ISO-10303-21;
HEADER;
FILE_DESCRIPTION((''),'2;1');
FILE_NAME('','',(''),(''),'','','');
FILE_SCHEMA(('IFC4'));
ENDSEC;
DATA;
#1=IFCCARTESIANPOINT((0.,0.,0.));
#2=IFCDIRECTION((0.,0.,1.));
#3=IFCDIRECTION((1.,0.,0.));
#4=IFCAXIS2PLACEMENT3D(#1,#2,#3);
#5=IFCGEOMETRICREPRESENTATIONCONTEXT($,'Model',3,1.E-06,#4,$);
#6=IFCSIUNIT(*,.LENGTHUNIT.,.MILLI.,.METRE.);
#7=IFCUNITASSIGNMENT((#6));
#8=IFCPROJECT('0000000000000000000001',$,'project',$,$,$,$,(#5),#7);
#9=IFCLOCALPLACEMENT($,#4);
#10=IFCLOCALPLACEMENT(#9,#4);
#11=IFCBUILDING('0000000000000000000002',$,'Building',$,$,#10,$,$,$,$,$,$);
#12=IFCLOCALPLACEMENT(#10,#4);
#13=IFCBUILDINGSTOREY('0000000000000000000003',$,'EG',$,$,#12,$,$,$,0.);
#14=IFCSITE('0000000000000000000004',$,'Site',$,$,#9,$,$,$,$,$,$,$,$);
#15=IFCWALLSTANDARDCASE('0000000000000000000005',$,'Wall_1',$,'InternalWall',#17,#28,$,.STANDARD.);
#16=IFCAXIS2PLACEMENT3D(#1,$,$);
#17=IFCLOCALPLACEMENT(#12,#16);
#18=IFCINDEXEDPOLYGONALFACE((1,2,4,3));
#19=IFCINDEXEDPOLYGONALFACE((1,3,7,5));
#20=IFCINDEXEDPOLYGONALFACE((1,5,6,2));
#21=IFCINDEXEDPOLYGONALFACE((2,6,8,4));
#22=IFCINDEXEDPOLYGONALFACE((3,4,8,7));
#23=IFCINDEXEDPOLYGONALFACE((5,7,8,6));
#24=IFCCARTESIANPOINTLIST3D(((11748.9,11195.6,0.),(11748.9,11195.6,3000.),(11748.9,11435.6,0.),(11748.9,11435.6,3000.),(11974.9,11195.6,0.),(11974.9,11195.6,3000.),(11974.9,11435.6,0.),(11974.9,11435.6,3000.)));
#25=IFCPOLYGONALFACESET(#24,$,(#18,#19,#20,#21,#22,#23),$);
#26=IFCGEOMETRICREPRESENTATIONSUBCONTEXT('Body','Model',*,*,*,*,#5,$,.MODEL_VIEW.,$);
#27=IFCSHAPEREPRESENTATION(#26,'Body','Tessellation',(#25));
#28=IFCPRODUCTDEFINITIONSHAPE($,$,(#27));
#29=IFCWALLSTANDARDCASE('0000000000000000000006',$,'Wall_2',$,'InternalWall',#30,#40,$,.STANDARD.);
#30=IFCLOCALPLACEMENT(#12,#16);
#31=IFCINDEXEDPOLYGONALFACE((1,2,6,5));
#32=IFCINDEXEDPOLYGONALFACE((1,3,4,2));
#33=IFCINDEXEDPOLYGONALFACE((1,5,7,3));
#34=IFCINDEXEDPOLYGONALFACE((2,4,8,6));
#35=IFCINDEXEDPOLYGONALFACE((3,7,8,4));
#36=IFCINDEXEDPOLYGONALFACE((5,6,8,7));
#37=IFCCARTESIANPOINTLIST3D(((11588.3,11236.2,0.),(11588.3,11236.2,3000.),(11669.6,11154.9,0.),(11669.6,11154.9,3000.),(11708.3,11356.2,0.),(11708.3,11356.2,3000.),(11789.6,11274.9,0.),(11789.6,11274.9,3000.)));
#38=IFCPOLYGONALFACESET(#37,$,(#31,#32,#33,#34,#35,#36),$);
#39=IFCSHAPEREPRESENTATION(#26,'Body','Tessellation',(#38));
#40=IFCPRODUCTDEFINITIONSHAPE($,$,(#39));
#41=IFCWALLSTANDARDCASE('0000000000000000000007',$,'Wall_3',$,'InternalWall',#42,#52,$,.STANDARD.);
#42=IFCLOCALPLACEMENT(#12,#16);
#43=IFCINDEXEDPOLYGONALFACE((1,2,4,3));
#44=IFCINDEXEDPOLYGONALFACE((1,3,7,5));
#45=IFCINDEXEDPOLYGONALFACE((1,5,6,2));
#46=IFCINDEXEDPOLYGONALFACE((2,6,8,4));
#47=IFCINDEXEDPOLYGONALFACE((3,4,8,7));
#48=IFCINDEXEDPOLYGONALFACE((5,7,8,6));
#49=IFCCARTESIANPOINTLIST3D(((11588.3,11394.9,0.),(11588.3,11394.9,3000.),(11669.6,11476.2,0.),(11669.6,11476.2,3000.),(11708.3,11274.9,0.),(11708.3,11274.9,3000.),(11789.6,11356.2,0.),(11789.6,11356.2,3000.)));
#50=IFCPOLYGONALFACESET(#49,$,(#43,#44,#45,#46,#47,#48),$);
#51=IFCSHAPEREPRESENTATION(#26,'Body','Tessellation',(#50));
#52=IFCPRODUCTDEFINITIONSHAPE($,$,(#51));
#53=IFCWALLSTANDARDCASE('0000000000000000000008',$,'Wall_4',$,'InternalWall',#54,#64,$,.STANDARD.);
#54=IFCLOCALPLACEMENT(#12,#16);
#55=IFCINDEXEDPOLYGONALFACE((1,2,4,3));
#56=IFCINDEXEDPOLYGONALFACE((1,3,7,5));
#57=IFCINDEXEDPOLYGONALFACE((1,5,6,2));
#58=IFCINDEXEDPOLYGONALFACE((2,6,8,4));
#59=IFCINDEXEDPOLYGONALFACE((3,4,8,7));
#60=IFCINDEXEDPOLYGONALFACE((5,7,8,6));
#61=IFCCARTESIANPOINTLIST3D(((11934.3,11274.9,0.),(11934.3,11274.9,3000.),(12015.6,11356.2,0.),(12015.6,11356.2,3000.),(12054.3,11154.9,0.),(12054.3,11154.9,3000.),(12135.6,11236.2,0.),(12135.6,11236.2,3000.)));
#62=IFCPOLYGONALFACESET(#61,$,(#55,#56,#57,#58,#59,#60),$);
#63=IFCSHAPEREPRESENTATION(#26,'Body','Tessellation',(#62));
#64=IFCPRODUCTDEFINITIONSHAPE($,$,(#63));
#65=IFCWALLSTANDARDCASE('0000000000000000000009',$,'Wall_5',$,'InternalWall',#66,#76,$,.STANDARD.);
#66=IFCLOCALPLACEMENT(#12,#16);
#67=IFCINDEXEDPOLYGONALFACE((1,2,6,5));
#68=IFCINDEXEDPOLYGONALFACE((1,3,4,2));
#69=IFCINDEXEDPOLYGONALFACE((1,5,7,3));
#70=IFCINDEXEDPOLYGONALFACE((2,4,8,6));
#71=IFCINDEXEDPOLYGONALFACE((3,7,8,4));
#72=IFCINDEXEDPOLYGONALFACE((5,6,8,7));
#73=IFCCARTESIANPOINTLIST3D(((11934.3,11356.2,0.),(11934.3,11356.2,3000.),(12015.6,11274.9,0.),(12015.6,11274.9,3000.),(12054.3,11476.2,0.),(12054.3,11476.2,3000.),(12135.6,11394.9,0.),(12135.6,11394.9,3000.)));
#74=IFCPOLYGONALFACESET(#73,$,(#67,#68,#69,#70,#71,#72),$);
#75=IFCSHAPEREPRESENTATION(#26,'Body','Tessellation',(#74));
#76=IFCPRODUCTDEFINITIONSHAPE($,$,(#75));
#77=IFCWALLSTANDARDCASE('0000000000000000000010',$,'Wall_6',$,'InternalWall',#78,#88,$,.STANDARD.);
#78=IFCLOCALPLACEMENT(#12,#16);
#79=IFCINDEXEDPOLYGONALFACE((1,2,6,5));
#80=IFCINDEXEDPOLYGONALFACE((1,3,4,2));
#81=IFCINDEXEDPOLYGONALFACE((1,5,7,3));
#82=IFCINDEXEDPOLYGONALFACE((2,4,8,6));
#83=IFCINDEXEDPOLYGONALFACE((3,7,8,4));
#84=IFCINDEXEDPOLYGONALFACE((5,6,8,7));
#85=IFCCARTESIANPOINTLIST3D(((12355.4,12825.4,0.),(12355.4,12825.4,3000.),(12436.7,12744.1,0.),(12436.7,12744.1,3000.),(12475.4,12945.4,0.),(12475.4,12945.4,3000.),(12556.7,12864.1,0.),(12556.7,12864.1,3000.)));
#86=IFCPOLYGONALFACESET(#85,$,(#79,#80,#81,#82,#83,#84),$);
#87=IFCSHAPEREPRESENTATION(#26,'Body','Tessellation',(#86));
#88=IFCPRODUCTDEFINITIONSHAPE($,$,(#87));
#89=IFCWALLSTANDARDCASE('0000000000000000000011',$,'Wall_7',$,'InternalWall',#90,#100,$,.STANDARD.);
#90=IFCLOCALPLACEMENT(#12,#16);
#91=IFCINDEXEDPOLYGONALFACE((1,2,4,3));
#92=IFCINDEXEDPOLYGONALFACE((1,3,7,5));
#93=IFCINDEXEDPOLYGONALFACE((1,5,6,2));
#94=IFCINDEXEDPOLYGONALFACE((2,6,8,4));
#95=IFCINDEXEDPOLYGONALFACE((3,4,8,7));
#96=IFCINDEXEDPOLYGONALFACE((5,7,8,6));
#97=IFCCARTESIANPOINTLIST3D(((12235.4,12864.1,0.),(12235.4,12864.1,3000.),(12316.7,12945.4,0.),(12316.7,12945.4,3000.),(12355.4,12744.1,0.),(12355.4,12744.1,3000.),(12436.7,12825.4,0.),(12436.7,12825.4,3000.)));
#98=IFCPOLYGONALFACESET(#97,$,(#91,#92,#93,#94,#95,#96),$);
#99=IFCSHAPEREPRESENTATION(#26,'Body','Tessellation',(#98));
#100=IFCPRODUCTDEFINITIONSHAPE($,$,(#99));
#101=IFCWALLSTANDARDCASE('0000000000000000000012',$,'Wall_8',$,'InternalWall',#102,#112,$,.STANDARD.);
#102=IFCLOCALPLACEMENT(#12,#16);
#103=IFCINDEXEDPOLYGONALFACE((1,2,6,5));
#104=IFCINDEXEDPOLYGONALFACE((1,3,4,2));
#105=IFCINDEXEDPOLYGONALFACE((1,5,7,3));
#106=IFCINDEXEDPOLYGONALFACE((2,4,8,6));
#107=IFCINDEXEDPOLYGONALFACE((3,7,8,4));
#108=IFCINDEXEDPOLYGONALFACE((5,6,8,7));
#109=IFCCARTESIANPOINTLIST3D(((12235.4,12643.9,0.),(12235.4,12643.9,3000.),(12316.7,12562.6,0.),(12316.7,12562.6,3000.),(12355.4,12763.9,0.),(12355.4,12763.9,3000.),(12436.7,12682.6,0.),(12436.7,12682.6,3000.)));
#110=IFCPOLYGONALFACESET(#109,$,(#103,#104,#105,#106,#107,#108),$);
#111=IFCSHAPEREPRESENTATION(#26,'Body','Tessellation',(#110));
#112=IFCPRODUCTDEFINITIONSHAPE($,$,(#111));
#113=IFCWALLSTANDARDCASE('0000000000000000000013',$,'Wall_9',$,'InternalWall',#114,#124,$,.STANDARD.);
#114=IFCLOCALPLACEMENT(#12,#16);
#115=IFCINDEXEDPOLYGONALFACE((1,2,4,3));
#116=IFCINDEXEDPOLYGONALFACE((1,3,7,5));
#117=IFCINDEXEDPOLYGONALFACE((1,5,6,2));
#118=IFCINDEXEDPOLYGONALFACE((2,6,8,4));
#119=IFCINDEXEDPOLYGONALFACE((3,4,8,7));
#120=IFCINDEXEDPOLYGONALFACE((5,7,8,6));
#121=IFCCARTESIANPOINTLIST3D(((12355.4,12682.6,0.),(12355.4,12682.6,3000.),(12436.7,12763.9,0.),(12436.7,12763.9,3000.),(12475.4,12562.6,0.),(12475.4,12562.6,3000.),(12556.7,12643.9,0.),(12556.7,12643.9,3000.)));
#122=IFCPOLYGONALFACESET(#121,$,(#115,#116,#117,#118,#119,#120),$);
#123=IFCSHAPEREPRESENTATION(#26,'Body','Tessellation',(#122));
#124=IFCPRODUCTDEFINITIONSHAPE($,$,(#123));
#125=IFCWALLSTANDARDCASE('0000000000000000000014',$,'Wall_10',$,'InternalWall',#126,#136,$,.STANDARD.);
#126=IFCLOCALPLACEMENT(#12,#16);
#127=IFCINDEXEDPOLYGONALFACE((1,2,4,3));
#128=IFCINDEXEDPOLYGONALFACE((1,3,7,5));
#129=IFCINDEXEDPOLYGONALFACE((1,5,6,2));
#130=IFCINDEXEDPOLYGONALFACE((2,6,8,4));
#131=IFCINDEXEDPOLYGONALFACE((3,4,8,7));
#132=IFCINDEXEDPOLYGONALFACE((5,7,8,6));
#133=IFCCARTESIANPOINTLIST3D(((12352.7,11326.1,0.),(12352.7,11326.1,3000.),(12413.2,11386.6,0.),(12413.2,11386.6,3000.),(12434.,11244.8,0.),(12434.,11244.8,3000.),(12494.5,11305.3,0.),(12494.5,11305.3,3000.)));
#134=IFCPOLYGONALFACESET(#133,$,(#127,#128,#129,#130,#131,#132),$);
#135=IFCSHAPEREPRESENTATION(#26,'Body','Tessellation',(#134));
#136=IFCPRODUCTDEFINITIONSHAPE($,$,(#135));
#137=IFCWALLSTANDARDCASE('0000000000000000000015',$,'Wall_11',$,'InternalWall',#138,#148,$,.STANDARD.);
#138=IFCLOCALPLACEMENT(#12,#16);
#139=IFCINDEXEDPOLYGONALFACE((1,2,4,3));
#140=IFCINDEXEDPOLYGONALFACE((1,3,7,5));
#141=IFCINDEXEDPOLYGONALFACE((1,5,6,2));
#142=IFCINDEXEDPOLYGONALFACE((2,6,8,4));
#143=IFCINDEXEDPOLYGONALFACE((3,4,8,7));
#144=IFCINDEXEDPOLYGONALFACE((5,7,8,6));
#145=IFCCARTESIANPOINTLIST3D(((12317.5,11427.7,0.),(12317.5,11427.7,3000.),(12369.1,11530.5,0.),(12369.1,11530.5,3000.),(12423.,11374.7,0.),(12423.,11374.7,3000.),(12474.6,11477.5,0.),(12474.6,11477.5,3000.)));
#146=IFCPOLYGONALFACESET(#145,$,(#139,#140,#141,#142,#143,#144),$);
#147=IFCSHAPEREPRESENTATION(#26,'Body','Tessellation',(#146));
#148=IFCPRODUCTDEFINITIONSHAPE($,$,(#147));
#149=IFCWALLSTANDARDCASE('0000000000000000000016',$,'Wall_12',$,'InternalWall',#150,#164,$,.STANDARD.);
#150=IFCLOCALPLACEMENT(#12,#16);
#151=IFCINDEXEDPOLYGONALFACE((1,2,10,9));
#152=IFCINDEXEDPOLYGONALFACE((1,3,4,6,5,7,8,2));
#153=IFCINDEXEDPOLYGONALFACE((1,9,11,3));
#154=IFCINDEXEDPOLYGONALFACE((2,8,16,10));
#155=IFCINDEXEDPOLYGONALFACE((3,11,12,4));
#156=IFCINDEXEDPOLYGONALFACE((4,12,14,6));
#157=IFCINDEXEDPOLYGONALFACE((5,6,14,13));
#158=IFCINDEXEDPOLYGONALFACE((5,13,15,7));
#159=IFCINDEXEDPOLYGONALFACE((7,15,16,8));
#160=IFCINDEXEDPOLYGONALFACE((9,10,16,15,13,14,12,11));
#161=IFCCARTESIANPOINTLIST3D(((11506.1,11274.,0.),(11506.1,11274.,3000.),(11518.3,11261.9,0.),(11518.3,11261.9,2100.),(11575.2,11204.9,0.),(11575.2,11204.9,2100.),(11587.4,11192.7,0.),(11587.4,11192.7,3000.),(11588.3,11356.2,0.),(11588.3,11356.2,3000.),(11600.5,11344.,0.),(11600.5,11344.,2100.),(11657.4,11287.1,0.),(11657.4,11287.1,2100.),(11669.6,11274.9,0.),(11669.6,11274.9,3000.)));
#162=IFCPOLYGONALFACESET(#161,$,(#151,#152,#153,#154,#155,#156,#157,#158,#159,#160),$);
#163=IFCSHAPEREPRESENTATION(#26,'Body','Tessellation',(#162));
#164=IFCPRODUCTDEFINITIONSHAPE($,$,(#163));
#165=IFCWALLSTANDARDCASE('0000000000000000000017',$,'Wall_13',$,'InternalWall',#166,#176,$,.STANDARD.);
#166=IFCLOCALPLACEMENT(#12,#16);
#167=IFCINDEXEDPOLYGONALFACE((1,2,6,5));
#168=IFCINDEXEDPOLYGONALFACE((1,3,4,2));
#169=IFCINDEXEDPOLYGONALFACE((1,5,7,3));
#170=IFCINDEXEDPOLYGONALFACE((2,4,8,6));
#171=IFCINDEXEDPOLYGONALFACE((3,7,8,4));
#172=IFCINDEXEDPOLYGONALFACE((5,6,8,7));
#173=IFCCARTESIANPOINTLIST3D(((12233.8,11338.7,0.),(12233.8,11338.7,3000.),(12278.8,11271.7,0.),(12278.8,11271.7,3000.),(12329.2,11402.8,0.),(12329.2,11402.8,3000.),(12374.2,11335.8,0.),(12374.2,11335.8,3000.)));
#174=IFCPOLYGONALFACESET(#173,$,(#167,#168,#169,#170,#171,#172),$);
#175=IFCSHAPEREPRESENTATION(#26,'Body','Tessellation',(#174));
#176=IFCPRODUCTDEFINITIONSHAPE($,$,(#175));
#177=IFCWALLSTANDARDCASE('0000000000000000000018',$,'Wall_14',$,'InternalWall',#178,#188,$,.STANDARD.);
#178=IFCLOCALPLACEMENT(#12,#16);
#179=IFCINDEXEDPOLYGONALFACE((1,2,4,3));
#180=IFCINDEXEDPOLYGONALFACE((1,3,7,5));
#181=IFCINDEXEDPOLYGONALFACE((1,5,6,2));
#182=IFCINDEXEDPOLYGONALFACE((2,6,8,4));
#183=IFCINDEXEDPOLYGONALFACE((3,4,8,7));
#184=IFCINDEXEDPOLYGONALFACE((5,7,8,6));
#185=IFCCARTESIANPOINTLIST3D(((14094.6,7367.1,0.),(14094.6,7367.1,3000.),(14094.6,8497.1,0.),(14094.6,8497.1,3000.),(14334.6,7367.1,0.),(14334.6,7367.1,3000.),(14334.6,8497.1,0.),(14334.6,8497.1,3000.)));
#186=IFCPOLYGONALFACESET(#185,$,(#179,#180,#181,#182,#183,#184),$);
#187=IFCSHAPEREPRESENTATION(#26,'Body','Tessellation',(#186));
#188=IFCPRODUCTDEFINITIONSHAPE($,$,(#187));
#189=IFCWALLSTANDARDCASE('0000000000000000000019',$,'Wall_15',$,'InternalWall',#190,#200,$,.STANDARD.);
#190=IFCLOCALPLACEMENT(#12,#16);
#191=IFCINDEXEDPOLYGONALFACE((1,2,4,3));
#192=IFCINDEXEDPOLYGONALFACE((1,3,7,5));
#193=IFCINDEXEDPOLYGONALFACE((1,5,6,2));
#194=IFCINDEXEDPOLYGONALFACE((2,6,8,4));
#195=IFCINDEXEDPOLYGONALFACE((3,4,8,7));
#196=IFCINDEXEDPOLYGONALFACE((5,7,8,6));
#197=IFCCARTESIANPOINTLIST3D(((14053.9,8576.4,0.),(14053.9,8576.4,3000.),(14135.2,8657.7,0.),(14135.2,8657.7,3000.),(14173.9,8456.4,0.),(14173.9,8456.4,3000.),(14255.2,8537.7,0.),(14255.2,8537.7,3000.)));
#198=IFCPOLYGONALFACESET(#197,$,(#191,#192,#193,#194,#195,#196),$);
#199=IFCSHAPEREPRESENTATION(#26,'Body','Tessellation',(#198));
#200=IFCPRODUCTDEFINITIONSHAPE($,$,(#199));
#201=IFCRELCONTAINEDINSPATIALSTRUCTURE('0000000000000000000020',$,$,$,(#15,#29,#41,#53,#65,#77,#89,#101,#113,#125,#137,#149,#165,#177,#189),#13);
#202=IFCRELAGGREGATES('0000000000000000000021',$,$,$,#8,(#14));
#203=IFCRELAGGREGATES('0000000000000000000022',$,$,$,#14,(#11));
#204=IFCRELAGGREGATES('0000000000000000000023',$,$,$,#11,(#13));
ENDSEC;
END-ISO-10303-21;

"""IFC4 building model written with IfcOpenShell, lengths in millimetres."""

from ifc_helpers import new_model, si_unit, frame, origin_with_axes, place, context, subcontext, project, spatial, rectangle, extrude, element, save


model = new_model("IFC4")

# Units and contexts
model_context = context("Model", 3, precision=1e-06, world=origin_with_axes())
body_context = subcontext(model_context, "Body", "Model", "MODEL_VIEW")
ifc_project = project(units=[si_unit("LENGTHUNIT", "METRE", prefix="MILLI")], contexts=[model_context])

# Site, building, storey
site_placement = place(None, origin_with_axes())
site = spatial("IfcSite", under=ifc_project, at=site_placement, Name="Site")
building_placement = place(site_placement, origin_with_axes())
building = spatial("IfcBuilding", under=site, at=building_placement, Name="Building")
storey_placement = place(building_placement, origin_with_axes())
storey = spatial("IfcBuildingStorey", under=building, at=storey_placement, Name="EG", Elevation=0.0)

# Walls
wall_1_placement = place(storey_placement, origin_with_axes())
element("IfcWallStandardCase", 1, at=wall_1_placement, inside=storey, Name="Wall_1", ObjectType="InternalWall", PredefinedType="STANDARD", context=body_context, shape_type="SweptSolid", body=[
    extrude(rectangle(XDim=226.0, YDim=240.0), frame((11861.9, 11315.6, 0.0), z_axis=(0.0, 0.0, 1.0), x_axis=(1.0, 0.0, 0.0)), (0.0, 0.0, 1.0), 3000.0),
])
wall_2_placement = place(storey_placement, origin_with_axes())
element("IfcWallStandardCase", 2, at=wall_2_placement, inside=storey, Name="Wall_2", ObjectType="InternalWall", PredefinedType="STANDARD", context=body_context, shape_type="SweptSolid", body=[
    extrude(rectangle(XDim=169.7, YDim=115.0), frame((11688.9, 11255.6, 0.0), z_axis=(0.0, 0.0, 1.0), x_axis=(-0.707107, -0.707107, 0.0)), (0.0, 0.0, 1.0), 3000.0),
])
wall_3_placement = place(storey_placement, origin_with_axes())
element("IfcWallStandardCase", 3, at=wall_3_placement, inside=storey, Name="Wall_3", ObjectType="InternalWall", PredefinedType="STANDARD", context=body_context, shape_type="SweptSolid", body=[
    extrude(rectangle(XDim=169.7, YDim=115.0), frame((11688.9, 11375.6, 0.0), z_axis=(0.0, 0.0, 1.0), x_axis=(-0.707107, 0.707107, 0.0)), (0.0, 0.0, 1.0), 3000.0),
])
wall_4_placement = place(storey_placement, origin_with_axes())
element("IfcWallStandardCase", 4, at=wall_4_placement, inside=storey, Name="Wall_4", ObjectType="InternalWall", PredefinedType="STANDARD", context=body_context, shape_type="SweptSolid", body=[
    extrude(rectangle(XDim=169.7, YDim=115.0), frame((12034.9, 11255.6, 0.0), z_axis=(0.0, 0.0, 1.0), x_axis=(0.707107, -0.707107, 0.0)), (0.0, 0.0, 1.0), 3000.0),
])
wall_5_placement = place(storey_placement, origin_with_axes())
element("IfcWallStandardCase", 5, at=wall_5_placement, inside=storey, Name="Wall_5", ObjectType="InternalWall", PredefinedType="STANDARD", context=body_context, shape_type="SweptSolid", body=[
    extrude(rectangle(XDim=169.7, YDim=115.0), frame((12034.9, 11375.6, 0.0), z_axis=(0.0, 0.0, 1.0), x_axis=(0.707107, 0.707107, 0.0)), (0.0, 0.0, 1.0), 3000.0),
])
wall_6_placement = place(storey_placement, origin_with_axes())
element("IfcWallStandardCase", 6, at=wall_6_placement, inside=storey, Name="Wall_6", ObjectType="InternalWall", PredefinedType="STANDARD", context=body_context, shape_type="SweptSolid", body=[
    extrude(rectangle(XDim=169.7, YDim=115.0), frame((12456.1, 12844.8, 0.0), z_axis=(0.0, 0.0, 1.0), x_axis=(-0.707107, -0.707107, 0.0)), (0.0, 0.0, 1.0), 3000.0),
])
wall_7_placement = place(storey_placement, origin_with_axes())
element("IfcWallStandardCase", 7, at=wall_7_placement, inside=storey, Name="Wall_7", ObjectType="InternalWall", PredefinedType="STANDARD", context=body_context, shape_type="SweptSolid", body=[
    extrude(rectangle(XDim=169.7, YDim=115.0), frame((12336.1, 12844.8, 0.0), z_axis=(0.0, 0.0, 1.0), x_axis=(-0.707107, 0.707107, 0.0)), (0.0, 0.0, 1.0), 3000.0),
])
wall_8_placement = place(storey_placement, origin_with_axes())
element("IfcWallStandardCase", 8, at=wall_8_placement, inside=storey, Name="Wall_8", ObjectType="InternalWall", PredefinedType="STANDARD", context=body_context, shape_type="SweptSolid", body=[
    extrude(rectangle(XDim=169.7, YDim=115.0), frame((12336.1, 12663.3, 0.0), z_axis=(0.0, 0.0, 1.0), x_axis=(-0.707107, -0.707107, 0.0)), (0.0, 0.0, 1.0), 3000.0),
])
wall_9_placement = place(storey_placement, origin_with_axes())
element("IfcWallStandardCase", 9, at=wall_9_placement, inside=storey, Name="Wall_9", ObjectType="InternalWall", PredefinedType="STANDARD", context=body_context, shape_type="SweptSolid", body=[
    extrude(rectangle(XDim=169.7, YDim=115.0), frame((12456.1, 12663.3, 0.0), z_axis=(0.0, 0.0, 1.0), x_axis=(0.707107, -0.707107, 0.0)), (0.0, 0.0, 1.0), 3000.0),
])
wall_10_placement = place(storey_placement, origin_with_axes())
element("IfcWallStandardCase", 10, at=wall_10_placement, inside=storey, Name="Wall_10", ObjectType="InternalWall", PredefinedType="STANDARD", context=body_context, shape_type="SweptSolid", body=[
    extrude(rectangle(XDim=85.6, YDim=115.0), frame((12423.6, 11315.7, 0.0), z_axis=(0.0, 0.0, 1.0), x_axis=(-0.707107, -0.707107, 0.0)), (0.0, 0.0, 1.0), 3000.0),
])
wall_11_placement = place(storey_placement, origin_with_axes())
element("IfcWallStandardCase", 11, at=wall_11_placement, inside=storey, Name="Wall_11", ObjectType="InternalWall", PredefinedType="STANDARD", context=body_context, shape_type="SweptSolid", body=[
    extrude(rectangle(XDim=118.1, YDim=115.0), frame((12396.1, 11452.6, 0.0), z_axis=(0.0, 0.0, 1.0), x_axis=(0.893579, -0.448907, 0.0)), (0.0, 0.0, 1.0), 3000.0),
])

# Wall, opening
wall_12_placement = place(storey_placement, origin_with_axes())
wall_12 = element("IfcWallStandardCase", 12, at=wall_12_placement, inside=storey, Name="Wall_12", ObjectType="InternalWall", PredefinedType="STANDARD", context=body_context, shape_type="SweptSolid", body=[
    extrude(rectangle(XDim=116.2, YDim=115.0), frame((11587.8, 11274.5, 0.0), z_axis=(0.0, 0.0, 1.0), x_axis=(-0.707107, -0.707107, 0.0)), (0.0, 0.0, 1.0), 3000.0),
])
opening_placement = place(wall_12_placement, origin_with_axes())
element("IfcOpeningElement", 13, at=opening_placement, inside=storey, cuts=wall_12, context=body_context, shape_type="SweptSolid", body=[
    extrude(rectangle(XDim=922.9, YDim=80.5), frame((11431.0, 11117.6, 0.0), z_axis=(0.0, 0.0, 1.0), x_axis=(-0.707107, -0.707107, 0.0)), (0.0, 0.0, 1.0), 2100.0),
])

# Walls
wall_13_placement = place(storey_placement, origin_with_axes())
element("IfcWallStandardCase", 14, at=wall_13_placement, inside=storey, Name="Wall_13", ObjectType="InternalWall", PredefinedType="STANDARD", context=body_context, shape_type="SweptSolid", body=[
    extrude(rectangle(XDim=80.7, YDim=115.0), frame((12304.0, 11337.2, 0.0), z_axis=(0.0, 0.0, 1.0), x_axis=(0.557556, -0.830139, 0.0)), (0.0, 0.0, 1.0), 3000.0),
])
wall_14_placement = place(storey_placement, origin_with_axes())
element("IfcWallStandardCase", 15, at=wall_14_placement, inside=storey, Name="Wall_14", ObjectType="InternalWall", PredefinedType="STANDARD", context=body_context, shape_type="SweptSolid", body=[
    extrude(rectangle(XDim=1130.0, YDim=240.0), frame((14214.6, 7932.1, 0.0), z_axis=(0.0, 0.0, 1.0), x_axis=(0.0, -1.0, 0.0)), (0.0, 0.0, 1.0), 3000.0),
])
wall_15_placement = place(storey_placement, origin_with_axes())
element("IfcWallStandardCase", 16, at=wall_15_placement, inside=storey, Name="Wall_15", ObjectType="InternalWall", PredefinedType="STANDARD", context=body_context, shape_type="SweptSolid", body=[
    extrude(rectangle(XDim=169.7, YDim=115.0), frame((14154.6, 8557.1, 0.0), z_axis=(0.0, 0.0, 1.0), x_axis=(-0.707107, 0.707107, 0.0)), (0.0, 0.0, 1.0), 3000.0),
])

save(model, "model.ifc")
